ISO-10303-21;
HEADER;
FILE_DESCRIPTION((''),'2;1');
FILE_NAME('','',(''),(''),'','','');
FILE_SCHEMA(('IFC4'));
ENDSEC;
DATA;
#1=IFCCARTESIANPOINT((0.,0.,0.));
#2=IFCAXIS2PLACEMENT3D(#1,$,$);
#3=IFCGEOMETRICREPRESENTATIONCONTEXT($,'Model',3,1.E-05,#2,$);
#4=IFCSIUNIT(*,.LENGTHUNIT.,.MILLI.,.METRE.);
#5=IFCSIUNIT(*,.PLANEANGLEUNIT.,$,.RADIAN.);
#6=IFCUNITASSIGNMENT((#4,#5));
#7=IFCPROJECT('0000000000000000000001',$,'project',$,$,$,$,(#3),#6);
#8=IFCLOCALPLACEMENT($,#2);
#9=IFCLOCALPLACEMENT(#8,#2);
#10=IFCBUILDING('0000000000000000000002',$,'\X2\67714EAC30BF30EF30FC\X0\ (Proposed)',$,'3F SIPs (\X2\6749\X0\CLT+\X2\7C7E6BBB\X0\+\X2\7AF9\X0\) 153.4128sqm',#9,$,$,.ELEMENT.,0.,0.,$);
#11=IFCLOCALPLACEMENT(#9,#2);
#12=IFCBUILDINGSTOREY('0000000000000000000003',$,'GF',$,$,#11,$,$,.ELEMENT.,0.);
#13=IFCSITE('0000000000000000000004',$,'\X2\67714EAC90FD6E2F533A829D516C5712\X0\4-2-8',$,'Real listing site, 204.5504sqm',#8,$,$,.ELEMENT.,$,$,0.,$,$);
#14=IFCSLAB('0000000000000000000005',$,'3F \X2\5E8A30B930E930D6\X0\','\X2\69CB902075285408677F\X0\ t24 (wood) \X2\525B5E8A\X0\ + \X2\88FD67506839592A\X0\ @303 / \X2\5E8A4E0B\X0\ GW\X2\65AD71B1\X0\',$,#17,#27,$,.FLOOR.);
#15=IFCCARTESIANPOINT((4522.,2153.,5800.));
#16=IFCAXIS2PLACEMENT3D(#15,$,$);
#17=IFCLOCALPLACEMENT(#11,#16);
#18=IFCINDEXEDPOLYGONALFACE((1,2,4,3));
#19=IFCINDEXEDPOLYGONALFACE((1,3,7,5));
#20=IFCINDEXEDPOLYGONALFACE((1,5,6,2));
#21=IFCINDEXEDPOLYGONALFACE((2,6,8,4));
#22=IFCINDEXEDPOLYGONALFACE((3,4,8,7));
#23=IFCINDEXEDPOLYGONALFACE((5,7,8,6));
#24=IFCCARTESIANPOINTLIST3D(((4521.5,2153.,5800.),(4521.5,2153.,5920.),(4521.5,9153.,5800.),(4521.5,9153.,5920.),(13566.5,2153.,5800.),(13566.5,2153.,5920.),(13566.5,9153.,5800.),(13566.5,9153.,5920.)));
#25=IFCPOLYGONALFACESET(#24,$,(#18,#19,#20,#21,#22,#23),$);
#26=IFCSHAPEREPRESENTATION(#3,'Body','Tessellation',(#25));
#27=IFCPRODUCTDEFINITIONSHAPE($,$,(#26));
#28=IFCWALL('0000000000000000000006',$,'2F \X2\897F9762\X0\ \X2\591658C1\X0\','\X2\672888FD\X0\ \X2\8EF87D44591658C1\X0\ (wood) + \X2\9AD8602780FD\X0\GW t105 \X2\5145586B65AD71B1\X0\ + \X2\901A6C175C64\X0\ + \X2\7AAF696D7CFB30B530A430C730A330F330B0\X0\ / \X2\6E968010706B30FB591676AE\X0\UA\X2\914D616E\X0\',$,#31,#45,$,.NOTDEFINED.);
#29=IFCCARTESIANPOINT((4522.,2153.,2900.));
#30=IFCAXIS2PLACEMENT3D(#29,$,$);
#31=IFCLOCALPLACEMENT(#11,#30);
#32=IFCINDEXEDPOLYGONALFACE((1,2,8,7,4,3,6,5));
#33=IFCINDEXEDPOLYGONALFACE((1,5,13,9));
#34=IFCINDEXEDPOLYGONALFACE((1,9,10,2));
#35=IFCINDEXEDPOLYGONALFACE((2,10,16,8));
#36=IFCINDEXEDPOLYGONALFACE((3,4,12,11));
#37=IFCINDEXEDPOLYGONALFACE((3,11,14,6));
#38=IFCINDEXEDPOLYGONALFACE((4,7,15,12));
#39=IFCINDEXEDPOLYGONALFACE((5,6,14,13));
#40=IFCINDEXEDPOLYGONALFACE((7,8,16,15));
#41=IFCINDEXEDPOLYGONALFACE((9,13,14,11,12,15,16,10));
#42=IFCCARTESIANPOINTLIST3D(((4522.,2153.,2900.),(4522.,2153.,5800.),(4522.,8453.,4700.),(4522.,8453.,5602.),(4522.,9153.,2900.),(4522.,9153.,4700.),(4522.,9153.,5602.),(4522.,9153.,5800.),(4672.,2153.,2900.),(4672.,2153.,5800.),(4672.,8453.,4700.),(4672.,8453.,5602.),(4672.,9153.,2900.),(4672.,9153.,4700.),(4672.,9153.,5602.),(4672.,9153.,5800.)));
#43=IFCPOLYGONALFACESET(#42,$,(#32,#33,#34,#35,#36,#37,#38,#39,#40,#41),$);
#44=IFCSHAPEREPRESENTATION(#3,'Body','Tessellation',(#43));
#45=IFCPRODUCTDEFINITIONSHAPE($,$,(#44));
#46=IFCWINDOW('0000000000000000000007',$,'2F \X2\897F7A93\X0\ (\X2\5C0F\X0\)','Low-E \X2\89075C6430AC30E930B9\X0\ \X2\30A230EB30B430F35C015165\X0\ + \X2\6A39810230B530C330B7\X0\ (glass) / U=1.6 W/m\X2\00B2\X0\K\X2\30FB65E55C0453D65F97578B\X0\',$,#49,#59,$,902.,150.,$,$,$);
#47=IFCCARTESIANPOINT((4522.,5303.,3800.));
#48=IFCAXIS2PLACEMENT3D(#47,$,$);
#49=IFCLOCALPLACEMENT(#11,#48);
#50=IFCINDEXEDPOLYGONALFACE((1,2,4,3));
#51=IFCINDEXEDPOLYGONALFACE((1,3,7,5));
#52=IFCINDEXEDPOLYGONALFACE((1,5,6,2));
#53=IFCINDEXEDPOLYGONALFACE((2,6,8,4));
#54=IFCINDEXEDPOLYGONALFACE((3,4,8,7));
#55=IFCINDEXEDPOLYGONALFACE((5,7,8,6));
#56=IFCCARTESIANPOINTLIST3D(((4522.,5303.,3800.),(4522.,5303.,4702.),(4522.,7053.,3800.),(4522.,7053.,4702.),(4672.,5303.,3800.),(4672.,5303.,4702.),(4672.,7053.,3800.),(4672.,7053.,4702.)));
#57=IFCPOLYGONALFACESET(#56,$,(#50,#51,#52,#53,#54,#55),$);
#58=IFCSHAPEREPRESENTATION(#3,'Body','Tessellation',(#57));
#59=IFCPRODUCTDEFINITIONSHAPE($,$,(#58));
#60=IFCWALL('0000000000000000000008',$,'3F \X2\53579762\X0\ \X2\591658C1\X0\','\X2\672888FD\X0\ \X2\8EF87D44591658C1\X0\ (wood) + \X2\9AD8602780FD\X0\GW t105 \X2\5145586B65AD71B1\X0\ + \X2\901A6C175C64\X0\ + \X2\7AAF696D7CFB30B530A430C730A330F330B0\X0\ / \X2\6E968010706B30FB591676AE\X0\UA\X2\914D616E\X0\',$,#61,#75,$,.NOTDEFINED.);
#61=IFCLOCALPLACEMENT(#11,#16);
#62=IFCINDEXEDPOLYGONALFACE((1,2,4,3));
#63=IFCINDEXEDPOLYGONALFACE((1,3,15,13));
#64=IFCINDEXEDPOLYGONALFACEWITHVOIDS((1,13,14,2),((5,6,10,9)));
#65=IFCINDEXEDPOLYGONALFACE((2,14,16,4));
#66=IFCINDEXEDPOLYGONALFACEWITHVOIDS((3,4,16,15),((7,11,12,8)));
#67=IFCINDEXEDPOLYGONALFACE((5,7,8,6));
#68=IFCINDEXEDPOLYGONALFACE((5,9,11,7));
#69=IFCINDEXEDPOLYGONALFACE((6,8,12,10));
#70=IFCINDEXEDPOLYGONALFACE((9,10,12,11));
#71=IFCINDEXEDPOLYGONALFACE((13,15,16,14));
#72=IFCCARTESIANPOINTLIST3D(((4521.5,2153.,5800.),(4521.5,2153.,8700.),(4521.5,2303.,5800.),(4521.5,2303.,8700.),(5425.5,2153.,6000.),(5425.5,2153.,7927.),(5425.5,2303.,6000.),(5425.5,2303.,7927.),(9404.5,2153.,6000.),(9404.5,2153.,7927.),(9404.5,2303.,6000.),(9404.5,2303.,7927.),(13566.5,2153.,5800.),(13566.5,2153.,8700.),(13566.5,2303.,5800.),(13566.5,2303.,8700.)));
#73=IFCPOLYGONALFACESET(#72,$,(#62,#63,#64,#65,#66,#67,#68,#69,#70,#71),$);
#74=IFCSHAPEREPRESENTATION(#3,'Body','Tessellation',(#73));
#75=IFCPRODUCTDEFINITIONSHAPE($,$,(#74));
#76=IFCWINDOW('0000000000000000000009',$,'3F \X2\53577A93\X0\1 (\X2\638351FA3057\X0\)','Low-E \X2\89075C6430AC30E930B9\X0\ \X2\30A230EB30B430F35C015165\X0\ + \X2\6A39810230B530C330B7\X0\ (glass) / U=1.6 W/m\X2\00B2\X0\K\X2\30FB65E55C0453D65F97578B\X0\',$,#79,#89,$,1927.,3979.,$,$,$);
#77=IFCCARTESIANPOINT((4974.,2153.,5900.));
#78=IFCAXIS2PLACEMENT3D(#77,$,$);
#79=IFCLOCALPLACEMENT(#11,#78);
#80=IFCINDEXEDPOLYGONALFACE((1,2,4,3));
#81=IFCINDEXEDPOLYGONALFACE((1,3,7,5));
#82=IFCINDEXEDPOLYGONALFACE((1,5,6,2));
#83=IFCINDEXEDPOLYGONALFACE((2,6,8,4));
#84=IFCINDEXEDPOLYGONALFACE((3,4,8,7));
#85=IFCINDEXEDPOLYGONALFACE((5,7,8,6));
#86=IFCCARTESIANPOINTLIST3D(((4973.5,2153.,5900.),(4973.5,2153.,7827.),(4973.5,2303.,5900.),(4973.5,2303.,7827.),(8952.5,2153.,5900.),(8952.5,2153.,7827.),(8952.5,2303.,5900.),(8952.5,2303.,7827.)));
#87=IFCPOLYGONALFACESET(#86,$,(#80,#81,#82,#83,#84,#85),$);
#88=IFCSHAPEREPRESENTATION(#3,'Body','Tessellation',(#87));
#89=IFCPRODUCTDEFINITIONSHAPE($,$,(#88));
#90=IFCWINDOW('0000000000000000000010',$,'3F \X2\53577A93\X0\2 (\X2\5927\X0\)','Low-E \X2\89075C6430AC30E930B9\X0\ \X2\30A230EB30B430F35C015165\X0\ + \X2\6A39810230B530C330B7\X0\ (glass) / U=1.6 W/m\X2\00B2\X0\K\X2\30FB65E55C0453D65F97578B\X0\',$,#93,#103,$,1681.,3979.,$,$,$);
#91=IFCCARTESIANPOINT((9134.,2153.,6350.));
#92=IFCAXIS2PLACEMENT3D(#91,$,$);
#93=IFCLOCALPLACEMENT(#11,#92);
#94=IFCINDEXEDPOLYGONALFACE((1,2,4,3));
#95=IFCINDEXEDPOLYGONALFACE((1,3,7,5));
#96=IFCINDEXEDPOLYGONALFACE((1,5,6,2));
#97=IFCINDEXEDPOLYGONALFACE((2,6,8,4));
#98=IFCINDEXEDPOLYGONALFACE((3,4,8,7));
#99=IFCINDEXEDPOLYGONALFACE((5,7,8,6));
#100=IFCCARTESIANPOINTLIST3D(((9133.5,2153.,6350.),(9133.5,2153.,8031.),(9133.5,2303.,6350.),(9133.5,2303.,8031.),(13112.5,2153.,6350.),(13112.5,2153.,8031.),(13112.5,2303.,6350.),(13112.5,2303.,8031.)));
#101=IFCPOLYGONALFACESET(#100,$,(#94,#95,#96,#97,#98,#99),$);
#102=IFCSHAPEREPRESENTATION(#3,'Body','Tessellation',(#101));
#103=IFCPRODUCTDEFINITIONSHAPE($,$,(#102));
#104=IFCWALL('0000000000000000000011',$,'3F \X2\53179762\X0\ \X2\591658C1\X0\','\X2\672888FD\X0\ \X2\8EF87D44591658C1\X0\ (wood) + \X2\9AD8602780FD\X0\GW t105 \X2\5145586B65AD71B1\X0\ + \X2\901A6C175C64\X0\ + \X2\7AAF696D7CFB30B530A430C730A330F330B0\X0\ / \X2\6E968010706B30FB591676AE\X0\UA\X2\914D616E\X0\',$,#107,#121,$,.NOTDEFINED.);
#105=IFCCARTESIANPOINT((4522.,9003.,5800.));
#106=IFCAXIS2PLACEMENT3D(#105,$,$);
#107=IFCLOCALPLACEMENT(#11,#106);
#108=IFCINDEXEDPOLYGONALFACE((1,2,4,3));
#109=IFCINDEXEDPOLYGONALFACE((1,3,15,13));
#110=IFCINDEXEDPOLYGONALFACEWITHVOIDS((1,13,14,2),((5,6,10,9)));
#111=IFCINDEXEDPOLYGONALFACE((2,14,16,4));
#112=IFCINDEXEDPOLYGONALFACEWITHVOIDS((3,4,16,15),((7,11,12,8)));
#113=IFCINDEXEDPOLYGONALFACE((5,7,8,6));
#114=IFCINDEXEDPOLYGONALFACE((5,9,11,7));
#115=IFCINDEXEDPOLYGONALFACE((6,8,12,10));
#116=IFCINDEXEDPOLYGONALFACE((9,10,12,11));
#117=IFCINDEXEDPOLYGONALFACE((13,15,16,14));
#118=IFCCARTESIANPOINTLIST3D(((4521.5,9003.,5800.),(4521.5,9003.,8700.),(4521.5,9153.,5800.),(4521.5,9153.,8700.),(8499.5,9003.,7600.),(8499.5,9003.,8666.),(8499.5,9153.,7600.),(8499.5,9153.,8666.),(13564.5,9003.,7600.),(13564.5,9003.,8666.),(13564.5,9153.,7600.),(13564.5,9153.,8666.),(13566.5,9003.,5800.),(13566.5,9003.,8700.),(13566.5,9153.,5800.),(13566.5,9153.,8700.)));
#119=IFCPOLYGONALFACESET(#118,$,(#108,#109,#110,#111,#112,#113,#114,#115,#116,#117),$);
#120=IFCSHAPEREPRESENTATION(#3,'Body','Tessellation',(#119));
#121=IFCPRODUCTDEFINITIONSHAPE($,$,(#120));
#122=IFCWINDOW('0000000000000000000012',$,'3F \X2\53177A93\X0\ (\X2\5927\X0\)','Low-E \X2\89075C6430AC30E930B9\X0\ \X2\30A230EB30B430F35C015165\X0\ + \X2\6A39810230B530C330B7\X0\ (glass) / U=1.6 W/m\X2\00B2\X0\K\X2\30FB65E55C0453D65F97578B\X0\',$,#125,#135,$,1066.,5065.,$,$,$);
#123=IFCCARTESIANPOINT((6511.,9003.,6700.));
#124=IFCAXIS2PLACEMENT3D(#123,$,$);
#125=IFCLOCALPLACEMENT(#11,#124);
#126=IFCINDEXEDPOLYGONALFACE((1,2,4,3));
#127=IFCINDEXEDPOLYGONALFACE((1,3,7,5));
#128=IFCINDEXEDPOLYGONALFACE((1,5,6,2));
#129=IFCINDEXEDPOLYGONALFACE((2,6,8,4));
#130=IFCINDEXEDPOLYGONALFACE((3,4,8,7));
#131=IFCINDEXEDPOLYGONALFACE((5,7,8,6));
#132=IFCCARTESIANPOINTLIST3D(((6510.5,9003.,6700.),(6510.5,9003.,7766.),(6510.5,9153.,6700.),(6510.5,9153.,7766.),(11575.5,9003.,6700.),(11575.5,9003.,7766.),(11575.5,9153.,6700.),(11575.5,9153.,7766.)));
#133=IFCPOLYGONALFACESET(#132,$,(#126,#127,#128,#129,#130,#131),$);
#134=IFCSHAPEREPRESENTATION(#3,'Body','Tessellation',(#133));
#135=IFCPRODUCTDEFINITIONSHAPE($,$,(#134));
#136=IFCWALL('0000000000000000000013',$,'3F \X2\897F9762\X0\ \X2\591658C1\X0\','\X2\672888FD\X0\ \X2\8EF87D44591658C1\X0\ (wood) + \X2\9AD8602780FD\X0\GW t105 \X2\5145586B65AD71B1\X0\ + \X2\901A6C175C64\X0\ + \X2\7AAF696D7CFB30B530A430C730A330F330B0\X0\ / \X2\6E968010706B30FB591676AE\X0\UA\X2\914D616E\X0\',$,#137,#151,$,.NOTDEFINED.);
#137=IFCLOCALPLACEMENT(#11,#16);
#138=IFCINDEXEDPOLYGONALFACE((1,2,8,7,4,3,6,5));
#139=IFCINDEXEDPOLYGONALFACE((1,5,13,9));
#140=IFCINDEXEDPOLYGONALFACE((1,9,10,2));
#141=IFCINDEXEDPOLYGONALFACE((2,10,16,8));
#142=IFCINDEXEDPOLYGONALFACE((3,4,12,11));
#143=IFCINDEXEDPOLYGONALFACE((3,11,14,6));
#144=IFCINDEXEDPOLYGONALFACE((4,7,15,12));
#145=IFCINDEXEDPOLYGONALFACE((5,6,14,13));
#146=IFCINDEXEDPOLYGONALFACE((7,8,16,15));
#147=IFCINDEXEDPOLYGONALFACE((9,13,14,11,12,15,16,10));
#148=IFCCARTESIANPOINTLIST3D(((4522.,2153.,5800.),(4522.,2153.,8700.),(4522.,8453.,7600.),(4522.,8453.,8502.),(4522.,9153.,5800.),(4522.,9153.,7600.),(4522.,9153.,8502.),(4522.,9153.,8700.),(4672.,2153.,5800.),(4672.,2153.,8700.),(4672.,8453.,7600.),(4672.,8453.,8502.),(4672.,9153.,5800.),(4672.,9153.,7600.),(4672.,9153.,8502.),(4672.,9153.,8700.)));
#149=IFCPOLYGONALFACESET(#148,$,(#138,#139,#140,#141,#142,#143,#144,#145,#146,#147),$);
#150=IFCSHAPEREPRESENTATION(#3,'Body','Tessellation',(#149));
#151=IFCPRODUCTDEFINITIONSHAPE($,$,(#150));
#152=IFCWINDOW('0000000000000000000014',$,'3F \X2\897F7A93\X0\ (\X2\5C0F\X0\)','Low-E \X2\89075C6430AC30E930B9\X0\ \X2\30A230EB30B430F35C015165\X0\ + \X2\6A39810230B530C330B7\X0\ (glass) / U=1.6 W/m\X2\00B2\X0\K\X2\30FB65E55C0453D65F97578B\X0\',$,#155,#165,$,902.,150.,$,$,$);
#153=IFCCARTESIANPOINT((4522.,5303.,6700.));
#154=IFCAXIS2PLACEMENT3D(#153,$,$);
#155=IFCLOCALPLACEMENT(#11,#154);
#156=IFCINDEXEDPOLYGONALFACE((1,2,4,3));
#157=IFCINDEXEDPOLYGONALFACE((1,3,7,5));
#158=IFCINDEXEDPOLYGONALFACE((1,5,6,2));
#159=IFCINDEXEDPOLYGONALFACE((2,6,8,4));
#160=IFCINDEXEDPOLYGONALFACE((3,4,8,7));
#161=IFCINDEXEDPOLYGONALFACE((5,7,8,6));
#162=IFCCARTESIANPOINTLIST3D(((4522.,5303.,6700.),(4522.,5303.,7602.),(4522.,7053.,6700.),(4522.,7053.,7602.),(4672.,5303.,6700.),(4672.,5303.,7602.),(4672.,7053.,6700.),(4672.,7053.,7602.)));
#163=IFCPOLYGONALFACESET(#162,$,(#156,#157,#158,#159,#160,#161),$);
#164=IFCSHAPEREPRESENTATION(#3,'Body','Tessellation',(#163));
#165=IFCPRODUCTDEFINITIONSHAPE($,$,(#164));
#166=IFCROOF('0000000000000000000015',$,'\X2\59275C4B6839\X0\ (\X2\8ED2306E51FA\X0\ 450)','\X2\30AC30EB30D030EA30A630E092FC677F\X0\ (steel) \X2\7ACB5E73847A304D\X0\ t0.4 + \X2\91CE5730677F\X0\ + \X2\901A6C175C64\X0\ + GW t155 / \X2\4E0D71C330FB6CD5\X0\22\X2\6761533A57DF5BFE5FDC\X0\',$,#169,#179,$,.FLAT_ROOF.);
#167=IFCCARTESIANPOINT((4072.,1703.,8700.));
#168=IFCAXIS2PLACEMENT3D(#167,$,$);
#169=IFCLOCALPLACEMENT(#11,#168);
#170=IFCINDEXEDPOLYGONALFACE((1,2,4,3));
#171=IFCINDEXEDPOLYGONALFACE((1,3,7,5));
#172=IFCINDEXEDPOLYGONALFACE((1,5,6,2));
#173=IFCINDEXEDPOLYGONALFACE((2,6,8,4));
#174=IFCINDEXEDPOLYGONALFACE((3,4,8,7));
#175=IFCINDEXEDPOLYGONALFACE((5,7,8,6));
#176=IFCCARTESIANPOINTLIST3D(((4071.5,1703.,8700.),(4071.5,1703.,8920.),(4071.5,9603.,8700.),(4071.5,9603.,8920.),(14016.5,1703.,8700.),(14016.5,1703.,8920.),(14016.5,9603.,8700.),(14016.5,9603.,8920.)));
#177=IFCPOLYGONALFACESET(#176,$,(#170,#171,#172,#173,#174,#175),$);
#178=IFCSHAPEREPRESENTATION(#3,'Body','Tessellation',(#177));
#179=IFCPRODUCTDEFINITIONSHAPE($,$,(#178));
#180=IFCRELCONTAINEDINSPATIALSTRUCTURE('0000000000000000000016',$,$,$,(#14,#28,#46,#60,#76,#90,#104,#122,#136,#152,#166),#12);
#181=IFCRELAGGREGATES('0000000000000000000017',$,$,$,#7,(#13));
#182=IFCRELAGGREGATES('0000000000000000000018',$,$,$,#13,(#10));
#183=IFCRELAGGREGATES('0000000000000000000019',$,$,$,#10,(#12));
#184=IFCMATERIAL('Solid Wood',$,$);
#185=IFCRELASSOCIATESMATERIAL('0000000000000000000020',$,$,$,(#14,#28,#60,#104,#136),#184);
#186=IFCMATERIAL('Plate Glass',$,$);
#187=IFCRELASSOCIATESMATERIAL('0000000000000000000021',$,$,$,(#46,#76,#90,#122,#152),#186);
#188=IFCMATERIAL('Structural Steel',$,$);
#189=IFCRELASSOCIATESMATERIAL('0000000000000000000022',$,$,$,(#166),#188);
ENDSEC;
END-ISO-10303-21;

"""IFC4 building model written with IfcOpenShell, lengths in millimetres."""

from ifc_helpers import new_model, si_unit, frame, frame_2d, origin, place, context, project, spatial, rectangle, extrude, material, element, fill, save


model = new_model("IFC4")

# Units and contexts
model_context = context("Model", 3, precision=1e-05, world=origin())
ifc_project = project(units=[si_unit("LENGTHUNIT", "METRE", prefix="MILLI"), si_unit("PLANEANGLEUNIT", "RADIAN")], contexts=[model_context])

# Site, building, storey
site_placement = place(None, origin())
site = spatial("IfcSite", under=ifc_project, at=site_placement, Name="東京都港区芝公園4-2-8", ObjectType="Real listing site, 204.5504sqm", CompositionType="ELEMENT", RefElevation=0.0)
building_placement = place(site_placement, origin())
building = spatial("IfcBuilding", under=site, at=building_placement, Name="東京タワー (Proposed)", ObjectType="3F SIPs (杉CLT+籾殻+竹) 153.4128sqm", CompositionType="ELEMENT", ElevationOfRefHeight=0.0, ElevationOfTerrain=0.0)
storey_placement = place(building_placement, origin())
storey = spatial("IfcBuildingStorey", under=building, at=storey_placement, Name="GF", CompositionType="ELEMENT", Elevation=0.0)

# Slab
ifc_material_1 = material(Name="Solid Wood")
slab_placement = place(storey_placement, frame((4522.0, 2153.0, 5800.0)))
element("IfcSlab", 1, at=slab_placement, inside=storey, material=ifc_material_1, Name="3F 床スラブ", Description="構造用合板 t24 (wood) 剛床 + 製材根太 @303 / 床下 GW断熱", PredefinedType="FLOOR", context=model_context, shape_type="SweptSolid", body=[
    extrude(rectangle(XDim=9045.0, YDim=7000.0, at=frame_2d((4522.0, 3500.0))), frame((4522.0, 2153.0, 5800.0)), (0.0, 0.0, 1.0), 120.0),
])

# Wall, opening, window
wall_1_placement = place(storey_placement, frame((4522.0, 2153.0, 2900.0)))
wall_1 = element("IfcWall", 2, at=wall_1_placement, inside=storey, material=ifc_material_1, Name="2F 西面 外壁", Description="木製 軸組外壁 (wood) + 高性能GW t105 充填断熱 + 通気層 + 窯業系サイディング / 準耐火・外皮UA配慮", PredefinedType="NOTDEFINED", context=model_context, shape_type="SweptSolid", body=[
    extrude(rectangle(XDim=150.0, YDim=7000.0, at=frame_2d((75.0, 3500.0))), frame((4522.0, 2153.0, 2900.0)), (0.0, 0.0, 1.0), 2900.0),
])
opening_1_placement = place(storey_placement, frame((4522.0, 5303.0, 3800.0)))
opening_1 = element("IfcOpeningElement", 3, at=opening_1_placement, cuts=wall_1, PredefinedType="NOTDEFINED", context=model_context, shape_type="SweptSolid", body=[
    extrude(rectangle(XDim=150.0, YDim=1750.0, at=frame_2d((75.0, 875.0))), frame((4522.0, 5303.0, 3800.0)), (0.0, 0.0, 1.0), 902.0),
])
ifc_material_2 = material(Name="Plate Glass")
window_1_placement = place(storey_placement, frame((4522.0, 5303.0, 3800.0)))
window_1 = element("IfcWindow", 4, at=window_1_placement, inside=storey, material=ifc_material_2, Name="2F 西窓 (小)", Description="Low-E 複層ガラス アルゴン封入 + 樹脂サッシ (glass) / U=1.6 W/m²K・日射取得型", OverallHeight=902.0, OverallWidth=150.0, context=model_context, shape_type="SweptSolid", body=[
    extrude(rectangle(XDim=150.0, YDim=1750.0, at=frame_2d((75.0, 875.0))), frame((4522.0, 5303.0, 3800.0)), (0.0, 0.0, 1.0), 902.0),
])
fill(opening_1, window_1)

# Wall, openings, windows
wall_2_placement = place(storey_placement, frame((4522.0, 2153.0, 5800.0)))
wall_2 = element("IfcWall", 5, at=wall_2_placement, inside=storey, material=ifc_material_1, Name="3F 南面 外壁", Description="木製 軸組外壁 (wood) + 高性能GW t105 充填断熱 + 通気層 + 窯業系サイディング / 準耐火・外皮UA配慮", PredefinedType="NOTDEFINED", context=model_context, shape_type="SweptSolid", body=[
    extrude(rectangle(XDim=9045.0, YDim=150.0, at=frame_2d((4522.0, 75.0))), frame((4522.0, 2153.0, 5800.0)), (0.0, 0.0, 1.0), 2900.0),
])
opening_2_placement = place(storey_placement, frame((4974.0, 2153.0, 5900.0)))
opening_2 = element("IfcOpeningElement", 6, at=opening_2_placement, cuts=wall_2, PredefinedType="NOTDEFINED", context=model_context, shape_type="SweptSolid", body=[
    extrude(rectangle(XDim=3979.0, YDim=150.0, at=frame_2d((1989.0, 75.0))), frame((4974.0, 2153.0, 5900.0)), (0.0, 0.0, 1.0), 1927.0),
])
opening_3_placement = place(storey_placement, frame((9134.0, 2153.0, 6350.0)))
opening_3 = element("IfcOpeningElement", 7, at=opening_3_placement, cuts=wall_2, PredefinedType="NOTDEFINED", context=model_context, shape_type="SweptSolid", body=[
    extrude(rectangle(XDim=3979.0, YDim=150.0, at=frame_2d((1989.0, 75.0))), frame((9134.0, 2153.0, 6350.0)), (0.0, 0.0, 1.0), 1681.0),
])
window_2_placement = place(storey_placement, frame((4974.0, 2153.0, 5900.0)))
window_2 = element("IfcWindow", 8, at=window_2_placement, inside=storey, material=ifc_material_2, Name="3F 南窓1 (掃出し)", Description="Low-E 複層ガラス アルゴン封入 + 樹脂サッシ (glass) / U=1.6 W/m²K・日射取得型", OverallHeight=1927.0, OverallWidth=3979.0, context=model_context, shape_type="SweptSolid", body=[
    extrude(rectangle(XDim=3979.0, YDim=150.0, at=frame_2d((1989.0, 75.0))), frame((4974.0, 2153.0, 5900.0)), (0.0, 0.0, 1.0), 1927.0),
])
fill(opening_2, window_2)
window_3_placement = place(storey_placement, frame((9134.0, 2153.0, 6350.0)))
window_3 = element("IfcWindow", 9, at=window_3_placement, inside=storey, material=ifc_material_2, Name="3F 南窓2 (大)", Description="Low-E 複層ガラス アルゴン封入 + 樹脂サッシ (glass) / U=1.6 W/m²K・日射取得型", OverallHeight=1681.0, OverallWidth=3979.0, context=model_context, shape_type="SweptSolid", body=[
    extrude(rectangle(XDim=3979.0, YDim=150.0, at=frame_2d((1989.0, 75.0))), frame((9134.0, 2153.0, 6350.0)), (0.0, 0.0, 1.0), 1681.0),
])
fill(opening_3, window_3)

# Walls, openings, windows
wall_3_placement = place(storey_placement, frame((4522.0, 9003.0, 5800.0)))
wall_3 = element("IfcWall", 10, at=wall_3_placement, inside=storey, material=ifc_material_1, Name="3F 北面 外壁", Description="木製 軸組外壁 (wood) + 高性能GW t105 充填断熱 + 通気層 + 窯業系サイディング / 準耐火・外皮UA配慮", PredefinedType="NOTDEFINED", context=model_context, shape_type="SweptSolid", body=[
    extrude(rectangle(XDim=9045.0, YDim=150.0, at=frame_2d((4522.0, 75.0))), frame((4522.0, 9003.0, 5800.0)), (0.0, 0.0, 1.0), 2900.0),
])
opening_4_placement = place(storey_placement, frame((6511.0, 9003.0, 6700.0)))
opening_4 = element("IfcOpeningElement", 11, at=opening_4_placement, cuts=wall_3, PredefinedType="NOTDEFINED", context=model_context, shape_type="SweptSolid", body=[
    extrude(rectangle(XDim=5065.0, YDim=150.0, at=frame_2d((2532.0, 75.0))), frame((6511.0, 9003.0, 6700.0)), (0.0, 0.0, 1.0), 1066.0),
])
window_4_placement = place(storey_placement, frame((6511.0, 9003.0, 6700.0)))
window_4 = element("IfcWindow", 12, at=window_4_placement, inside=storey, material=ifc_material_2, Name="3F 北窓 (大)", Description="Low-E 複層ガラス アルゴン封入 + 樹脂サッシ (glass) / U=1.6 W/m²K・日射取得型", OverallHeight=1066.0, OverallWidth=5065.0, context=model_context, shape_type="SweptSolid", body=[
    extrude(rectangle(XDim=5065.0, YDim=150.0, at=frame_2d((2532.0, 75.0))), frame((6511.0, 9003.0, 6700.0)), (0.0, 0.0, 1.0), 1066.0),
])
fill(opening_4, window_4)
wall_4_placement = place(storey_placement, frame((4522.0, 2153.0, 5800.0)))
wall_4 = element("IfcWall", 13, at=wall_4_placement, inside=storey, material=ifc_material_1, Name="3F 西面 外壁", Description="木製 軸組外壁 (wood) + 高性能GW t105 充填断熱 + 通気層 + 窯業系サイディング / 準耐火・外皮UA配慮", PredefinedType="NOTDEFINED", context=model_context, shape_type="SweptSolid", body=[
    extrude(rectangle(XDim=150.0, YDim=7000.0, at=frame_2d((75.0, 3500.0))), frame((4522.0, 2153.0, 5800.0)), (0.0, 0.0, 1.0), 2900.0),
])
opening_5_placement = place(storey_placement, frame((4522.0, 5303.0, 6700.0)))
opening_5 = element("IfcOpeningElement", 14, at=opening_5_placement, cuts=wall_4, PredefinedType="NOTDEFINED", context=model_context, shape_type="SweptSolid", body=[
    extrude(rectangle(XDim=150.0, YDim=1750.0, at=frame_2d((75.0, 875.0))), frame((4522.0, 5303.0, 6700.0)), (0.0, 0.0, 1.0), 902.0),
])
window_5_placement = place(storey_placement, frame((4522.0, 5303.0, 6700.0)))
window_5 = element("IfcWindow", 15, at=window_5_placement, inside=storey, material=ifc_material_2, Name="3F 西窓 (小)", Description="Low-E 複層ガラス アルゴン封入 + 樹脂サッシ (glass) / U=1.6 W/m²K・日射取得型", OverallHeight=902.0, OverallWidth=150.0, context=model_context, shape_type="SweptSolid", body=[
    extrude(rectangle(XDim=150.0, YDim=1750.0, at=frame_2d((75.0, 875.0))), frame((4522.0, 5303.0, 6700.0)), (0.0, 0.0, 1.0), 902.0),
])
fill(opening_5, window_5)

# Roof
ifc_material_3 = material(Name="Structural Steel")
roof_1_placement = place(storey_placement, frame((4072.0, 1703.0, 8700.0)))
element("IfcRoof", 16, at=roof_1_placement, inside=storey, material=ifc_material_3, Name="大屋根 (軒の出 450)", Description="ガルバリウム鋼板 (steel) 立平葺き t0.4 + 野地板 + 通気層 + GW t155 / 不燃・法22条区域対応", PredefinedType="FLAT_ROOF", context=model_context, shape_type="SweptSolid", body=[
    extrude(rectangle(XDim=9945.0, YDim=7900.0, at=frame_2d((4972.0, 3950.0))), frame((4072.0, 1703.0, 8700.0)), (0.0, 0.0, 1.0), 220.0),
])

save(model, "model.ifc")
